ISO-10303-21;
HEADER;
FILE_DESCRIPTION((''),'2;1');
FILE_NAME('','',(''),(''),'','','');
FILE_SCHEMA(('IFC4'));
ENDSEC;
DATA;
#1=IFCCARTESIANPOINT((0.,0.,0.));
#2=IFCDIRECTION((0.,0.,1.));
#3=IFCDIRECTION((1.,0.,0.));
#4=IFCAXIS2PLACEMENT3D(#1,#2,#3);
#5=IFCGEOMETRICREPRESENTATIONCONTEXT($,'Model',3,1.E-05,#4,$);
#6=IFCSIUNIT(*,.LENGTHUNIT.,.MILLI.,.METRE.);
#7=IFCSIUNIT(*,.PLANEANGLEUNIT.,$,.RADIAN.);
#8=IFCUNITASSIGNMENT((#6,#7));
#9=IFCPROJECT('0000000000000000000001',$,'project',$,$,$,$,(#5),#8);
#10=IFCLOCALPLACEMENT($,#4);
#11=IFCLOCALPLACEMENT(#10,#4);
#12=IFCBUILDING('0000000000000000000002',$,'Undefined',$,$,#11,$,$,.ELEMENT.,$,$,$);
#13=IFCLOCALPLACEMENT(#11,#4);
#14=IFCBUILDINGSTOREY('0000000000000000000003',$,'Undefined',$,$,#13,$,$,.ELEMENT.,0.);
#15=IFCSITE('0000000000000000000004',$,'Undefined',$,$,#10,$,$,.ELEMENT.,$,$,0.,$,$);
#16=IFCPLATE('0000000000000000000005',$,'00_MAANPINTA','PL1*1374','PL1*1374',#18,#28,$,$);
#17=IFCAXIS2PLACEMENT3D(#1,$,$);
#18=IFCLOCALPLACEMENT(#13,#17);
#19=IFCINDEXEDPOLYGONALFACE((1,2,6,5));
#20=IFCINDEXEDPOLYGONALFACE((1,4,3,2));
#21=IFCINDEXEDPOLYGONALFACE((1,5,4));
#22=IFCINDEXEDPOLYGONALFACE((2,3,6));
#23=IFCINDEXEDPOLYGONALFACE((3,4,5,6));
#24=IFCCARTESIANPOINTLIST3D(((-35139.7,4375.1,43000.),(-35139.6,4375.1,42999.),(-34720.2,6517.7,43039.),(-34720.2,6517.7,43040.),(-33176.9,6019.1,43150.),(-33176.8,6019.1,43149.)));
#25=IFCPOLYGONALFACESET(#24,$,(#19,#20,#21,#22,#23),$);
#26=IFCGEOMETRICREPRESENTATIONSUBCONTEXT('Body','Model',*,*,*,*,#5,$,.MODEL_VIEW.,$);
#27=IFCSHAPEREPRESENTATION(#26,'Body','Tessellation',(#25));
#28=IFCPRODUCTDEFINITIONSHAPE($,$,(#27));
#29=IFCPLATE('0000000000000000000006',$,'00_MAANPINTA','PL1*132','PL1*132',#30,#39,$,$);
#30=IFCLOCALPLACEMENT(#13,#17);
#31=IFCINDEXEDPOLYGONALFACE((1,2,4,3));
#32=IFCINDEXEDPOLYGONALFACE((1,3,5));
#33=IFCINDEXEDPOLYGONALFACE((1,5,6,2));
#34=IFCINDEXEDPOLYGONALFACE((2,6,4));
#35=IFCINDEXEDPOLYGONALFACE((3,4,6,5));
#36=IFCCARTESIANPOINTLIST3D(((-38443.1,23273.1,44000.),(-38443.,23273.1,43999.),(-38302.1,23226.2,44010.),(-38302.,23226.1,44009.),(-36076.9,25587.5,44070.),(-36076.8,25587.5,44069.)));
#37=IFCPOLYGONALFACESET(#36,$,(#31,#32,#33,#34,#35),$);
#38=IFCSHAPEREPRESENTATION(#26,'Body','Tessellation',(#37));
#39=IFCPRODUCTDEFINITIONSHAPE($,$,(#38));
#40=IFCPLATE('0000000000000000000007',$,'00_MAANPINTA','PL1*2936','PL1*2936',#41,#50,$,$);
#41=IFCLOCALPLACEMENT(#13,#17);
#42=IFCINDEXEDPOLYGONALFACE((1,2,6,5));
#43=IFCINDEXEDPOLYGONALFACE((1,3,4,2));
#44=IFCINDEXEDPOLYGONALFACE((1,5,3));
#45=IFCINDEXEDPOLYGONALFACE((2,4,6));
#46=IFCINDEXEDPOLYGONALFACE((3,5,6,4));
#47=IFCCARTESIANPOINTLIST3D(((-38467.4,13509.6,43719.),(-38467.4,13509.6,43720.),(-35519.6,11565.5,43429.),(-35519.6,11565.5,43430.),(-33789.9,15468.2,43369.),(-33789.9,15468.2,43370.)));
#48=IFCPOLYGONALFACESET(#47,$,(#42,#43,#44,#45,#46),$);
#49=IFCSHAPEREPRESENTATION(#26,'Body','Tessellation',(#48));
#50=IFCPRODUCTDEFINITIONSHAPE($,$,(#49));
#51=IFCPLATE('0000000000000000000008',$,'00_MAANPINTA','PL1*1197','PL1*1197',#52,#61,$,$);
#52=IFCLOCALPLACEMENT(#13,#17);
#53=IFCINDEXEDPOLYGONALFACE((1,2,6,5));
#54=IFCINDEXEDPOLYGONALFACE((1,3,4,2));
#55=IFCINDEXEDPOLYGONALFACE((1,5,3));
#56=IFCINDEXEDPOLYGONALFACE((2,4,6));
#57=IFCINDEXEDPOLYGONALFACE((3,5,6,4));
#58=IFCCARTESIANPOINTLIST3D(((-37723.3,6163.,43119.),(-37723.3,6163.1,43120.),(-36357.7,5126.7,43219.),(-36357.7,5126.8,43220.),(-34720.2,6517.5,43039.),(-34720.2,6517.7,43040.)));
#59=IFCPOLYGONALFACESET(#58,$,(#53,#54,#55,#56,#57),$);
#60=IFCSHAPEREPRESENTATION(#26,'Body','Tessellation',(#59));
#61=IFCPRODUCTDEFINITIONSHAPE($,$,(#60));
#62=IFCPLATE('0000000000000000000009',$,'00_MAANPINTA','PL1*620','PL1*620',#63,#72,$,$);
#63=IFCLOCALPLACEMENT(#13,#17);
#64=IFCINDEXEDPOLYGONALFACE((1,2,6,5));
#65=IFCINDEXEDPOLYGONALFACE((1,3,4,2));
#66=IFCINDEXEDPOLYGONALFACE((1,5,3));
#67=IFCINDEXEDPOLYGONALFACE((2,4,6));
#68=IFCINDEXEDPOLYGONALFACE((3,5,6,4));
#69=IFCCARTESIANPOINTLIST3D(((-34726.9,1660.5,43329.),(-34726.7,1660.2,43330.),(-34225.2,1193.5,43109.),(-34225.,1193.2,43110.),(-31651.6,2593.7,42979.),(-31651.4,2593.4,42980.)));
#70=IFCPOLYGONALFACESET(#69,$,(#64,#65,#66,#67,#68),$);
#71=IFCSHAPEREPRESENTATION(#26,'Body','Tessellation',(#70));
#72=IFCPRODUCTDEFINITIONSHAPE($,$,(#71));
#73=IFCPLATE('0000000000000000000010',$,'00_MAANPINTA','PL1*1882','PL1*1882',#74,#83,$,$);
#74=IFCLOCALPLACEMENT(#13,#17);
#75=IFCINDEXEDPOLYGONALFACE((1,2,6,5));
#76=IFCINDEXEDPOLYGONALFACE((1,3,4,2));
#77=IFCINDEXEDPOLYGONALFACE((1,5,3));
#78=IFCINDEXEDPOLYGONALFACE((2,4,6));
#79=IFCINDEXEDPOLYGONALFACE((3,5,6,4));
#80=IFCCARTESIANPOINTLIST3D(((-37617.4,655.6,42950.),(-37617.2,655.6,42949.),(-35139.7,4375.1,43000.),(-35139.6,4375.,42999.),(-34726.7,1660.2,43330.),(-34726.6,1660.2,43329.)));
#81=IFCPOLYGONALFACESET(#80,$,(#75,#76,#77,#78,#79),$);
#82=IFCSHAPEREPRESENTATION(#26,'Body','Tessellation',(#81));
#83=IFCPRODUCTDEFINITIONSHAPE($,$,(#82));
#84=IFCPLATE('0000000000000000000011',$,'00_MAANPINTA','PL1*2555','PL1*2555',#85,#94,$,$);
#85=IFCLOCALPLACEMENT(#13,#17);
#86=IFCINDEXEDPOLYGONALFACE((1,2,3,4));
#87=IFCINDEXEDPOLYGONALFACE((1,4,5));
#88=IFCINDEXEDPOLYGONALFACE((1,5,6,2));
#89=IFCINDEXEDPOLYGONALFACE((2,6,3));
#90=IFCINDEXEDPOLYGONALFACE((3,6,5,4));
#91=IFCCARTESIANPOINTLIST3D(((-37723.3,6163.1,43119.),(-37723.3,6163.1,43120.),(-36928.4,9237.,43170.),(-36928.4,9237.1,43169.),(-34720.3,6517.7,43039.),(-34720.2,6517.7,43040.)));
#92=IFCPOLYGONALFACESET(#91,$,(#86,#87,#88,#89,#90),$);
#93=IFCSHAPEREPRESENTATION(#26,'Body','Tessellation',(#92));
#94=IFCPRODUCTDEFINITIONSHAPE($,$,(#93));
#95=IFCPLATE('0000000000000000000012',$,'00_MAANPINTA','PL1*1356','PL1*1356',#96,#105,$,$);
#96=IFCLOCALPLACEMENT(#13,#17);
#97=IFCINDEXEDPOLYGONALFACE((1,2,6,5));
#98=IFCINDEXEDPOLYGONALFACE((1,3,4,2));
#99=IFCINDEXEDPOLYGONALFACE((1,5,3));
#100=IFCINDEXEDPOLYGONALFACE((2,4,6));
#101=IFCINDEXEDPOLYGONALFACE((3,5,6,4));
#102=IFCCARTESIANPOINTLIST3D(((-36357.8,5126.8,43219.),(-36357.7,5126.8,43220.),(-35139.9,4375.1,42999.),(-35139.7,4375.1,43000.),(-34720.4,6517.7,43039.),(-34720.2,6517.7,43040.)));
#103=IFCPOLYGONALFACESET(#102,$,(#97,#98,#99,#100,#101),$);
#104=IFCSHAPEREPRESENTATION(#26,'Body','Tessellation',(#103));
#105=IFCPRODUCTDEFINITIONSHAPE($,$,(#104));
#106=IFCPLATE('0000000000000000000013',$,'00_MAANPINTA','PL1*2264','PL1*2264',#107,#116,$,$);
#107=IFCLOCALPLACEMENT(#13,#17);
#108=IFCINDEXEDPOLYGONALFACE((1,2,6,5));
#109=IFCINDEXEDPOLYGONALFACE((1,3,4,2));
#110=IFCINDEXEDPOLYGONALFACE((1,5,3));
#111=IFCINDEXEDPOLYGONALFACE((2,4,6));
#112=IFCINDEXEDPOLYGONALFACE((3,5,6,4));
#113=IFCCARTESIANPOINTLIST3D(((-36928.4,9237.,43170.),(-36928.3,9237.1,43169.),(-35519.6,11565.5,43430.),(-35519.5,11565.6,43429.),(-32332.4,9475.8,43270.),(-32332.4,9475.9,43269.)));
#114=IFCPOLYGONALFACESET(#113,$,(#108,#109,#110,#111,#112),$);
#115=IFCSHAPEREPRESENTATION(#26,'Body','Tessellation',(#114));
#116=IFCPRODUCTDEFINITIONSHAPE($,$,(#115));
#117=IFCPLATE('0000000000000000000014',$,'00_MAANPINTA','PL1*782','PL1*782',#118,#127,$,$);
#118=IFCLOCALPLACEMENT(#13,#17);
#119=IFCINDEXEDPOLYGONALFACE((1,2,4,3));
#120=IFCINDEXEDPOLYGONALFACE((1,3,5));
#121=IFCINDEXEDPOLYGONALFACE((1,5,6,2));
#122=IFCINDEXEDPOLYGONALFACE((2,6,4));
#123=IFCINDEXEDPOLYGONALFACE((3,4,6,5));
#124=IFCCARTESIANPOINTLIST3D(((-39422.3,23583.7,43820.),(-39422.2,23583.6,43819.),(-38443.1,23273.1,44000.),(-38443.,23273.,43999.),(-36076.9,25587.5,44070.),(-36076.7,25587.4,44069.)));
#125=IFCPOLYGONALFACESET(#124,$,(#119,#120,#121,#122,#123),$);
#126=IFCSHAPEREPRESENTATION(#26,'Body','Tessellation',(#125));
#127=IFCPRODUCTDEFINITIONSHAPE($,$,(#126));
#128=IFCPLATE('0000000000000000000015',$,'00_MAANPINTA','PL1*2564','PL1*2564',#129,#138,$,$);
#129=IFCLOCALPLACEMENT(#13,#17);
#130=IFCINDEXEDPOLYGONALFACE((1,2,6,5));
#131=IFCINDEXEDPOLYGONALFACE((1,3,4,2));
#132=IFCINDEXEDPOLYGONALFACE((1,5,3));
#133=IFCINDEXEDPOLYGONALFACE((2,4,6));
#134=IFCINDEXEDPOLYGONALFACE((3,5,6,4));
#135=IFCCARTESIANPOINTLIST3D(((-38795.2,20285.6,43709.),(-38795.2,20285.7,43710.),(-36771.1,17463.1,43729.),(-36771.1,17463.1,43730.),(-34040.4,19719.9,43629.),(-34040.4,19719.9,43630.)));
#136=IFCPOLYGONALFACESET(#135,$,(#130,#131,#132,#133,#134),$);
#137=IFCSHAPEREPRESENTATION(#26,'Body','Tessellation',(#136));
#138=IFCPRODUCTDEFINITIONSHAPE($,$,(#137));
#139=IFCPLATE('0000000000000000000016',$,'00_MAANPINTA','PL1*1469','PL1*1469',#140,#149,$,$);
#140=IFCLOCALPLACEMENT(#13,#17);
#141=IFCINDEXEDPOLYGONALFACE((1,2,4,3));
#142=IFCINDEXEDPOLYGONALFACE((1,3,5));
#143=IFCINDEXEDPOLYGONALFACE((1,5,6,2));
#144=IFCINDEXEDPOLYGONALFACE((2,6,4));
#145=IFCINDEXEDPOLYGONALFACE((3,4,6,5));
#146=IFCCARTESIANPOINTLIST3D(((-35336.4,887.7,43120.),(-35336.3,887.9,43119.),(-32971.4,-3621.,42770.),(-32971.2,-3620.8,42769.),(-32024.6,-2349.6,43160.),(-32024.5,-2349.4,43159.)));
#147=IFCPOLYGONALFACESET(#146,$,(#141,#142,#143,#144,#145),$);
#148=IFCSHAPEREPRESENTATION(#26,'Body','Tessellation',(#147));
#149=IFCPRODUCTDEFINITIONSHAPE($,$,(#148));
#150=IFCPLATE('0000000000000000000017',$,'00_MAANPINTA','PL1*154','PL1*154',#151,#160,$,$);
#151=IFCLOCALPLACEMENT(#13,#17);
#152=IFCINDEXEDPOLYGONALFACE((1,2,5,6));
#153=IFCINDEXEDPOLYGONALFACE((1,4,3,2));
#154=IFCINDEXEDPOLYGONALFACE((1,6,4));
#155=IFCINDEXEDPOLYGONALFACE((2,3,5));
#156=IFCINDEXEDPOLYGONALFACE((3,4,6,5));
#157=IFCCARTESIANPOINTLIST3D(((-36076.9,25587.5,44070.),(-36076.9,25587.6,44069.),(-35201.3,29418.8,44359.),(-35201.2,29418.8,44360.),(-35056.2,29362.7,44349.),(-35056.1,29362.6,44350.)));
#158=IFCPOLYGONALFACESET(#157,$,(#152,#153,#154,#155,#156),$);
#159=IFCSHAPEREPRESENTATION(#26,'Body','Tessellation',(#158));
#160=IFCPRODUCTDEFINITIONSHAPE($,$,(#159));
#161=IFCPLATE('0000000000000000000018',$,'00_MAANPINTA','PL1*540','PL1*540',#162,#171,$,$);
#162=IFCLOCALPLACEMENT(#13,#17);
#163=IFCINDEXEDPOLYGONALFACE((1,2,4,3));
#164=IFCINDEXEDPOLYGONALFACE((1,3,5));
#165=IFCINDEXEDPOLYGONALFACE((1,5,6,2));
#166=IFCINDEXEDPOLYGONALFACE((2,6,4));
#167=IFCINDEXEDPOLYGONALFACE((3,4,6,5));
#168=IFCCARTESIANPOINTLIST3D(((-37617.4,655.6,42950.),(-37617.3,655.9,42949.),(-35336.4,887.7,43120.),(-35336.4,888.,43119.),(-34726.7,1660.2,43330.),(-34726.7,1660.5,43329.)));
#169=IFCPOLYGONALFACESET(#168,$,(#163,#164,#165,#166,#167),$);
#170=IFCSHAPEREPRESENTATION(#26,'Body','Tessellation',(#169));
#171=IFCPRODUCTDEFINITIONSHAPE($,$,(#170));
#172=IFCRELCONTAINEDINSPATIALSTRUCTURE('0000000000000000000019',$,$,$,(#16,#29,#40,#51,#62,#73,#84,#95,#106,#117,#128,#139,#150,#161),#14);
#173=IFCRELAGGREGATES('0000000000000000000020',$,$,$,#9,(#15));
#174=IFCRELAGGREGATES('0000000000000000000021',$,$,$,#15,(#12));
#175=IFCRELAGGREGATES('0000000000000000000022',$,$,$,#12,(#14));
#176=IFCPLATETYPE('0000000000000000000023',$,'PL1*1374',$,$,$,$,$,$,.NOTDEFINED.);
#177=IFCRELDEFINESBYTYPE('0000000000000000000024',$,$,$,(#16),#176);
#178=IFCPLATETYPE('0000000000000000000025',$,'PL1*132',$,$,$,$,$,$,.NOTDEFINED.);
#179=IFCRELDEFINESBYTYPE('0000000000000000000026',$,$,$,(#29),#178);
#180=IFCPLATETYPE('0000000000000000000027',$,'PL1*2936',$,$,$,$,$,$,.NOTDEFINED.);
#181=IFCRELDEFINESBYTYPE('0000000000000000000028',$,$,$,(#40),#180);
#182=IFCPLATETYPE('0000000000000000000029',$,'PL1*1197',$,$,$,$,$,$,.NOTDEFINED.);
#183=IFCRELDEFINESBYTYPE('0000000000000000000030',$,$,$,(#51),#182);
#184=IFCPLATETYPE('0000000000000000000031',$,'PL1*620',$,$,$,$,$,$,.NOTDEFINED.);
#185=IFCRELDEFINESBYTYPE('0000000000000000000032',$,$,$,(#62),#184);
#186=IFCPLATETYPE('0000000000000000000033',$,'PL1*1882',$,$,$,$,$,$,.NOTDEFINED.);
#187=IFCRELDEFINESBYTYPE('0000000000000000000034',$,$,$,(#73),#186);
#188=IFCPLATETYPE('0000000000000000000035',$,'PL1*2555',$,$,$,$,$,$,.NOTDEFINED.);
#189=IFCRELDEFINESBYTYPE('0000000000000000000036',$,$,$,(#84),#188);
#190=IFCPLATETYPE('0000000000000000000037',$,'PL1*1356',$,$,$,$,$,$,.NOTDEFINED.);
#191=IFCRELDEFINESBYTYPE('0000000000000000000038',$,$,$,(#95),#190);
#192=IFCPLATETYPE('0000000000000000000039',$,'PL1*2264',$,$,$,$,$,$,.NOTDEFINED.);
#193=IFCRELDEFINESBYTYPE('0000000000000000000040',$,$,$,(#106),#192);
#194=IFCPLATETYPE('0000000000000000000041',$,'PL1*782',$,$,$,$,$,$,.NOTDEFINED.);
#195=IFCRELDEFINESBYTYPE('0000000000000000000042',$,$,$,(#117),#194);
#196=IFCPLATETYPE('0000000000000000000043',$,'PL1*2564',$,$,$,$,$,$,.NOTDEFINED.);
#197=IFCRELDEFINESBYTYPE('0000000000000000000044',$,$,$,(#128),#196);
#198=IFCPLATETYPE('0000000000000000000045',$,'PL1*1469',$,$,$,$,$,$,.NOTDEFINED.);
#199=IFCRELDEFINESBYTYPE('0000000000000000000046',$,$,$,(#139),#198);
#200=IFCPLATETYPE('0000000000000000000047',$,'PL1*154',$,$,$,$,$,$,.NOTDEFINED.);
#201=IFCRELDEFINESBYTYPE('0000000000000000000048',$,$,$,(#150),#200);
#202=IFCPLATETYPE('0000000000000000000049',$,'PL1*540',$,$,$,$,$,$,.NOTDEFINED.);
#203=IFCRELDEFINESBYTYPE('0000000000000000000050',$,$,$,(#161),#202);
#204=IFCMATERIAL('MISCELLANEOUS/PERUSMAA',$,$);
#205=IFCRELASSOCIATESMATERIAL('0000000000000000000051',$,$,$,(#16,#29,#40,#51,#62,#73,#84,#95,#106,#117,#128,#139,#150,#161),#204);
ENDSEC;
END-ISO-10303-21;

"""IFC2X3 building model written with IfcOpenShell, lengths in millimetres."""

from ifc_helpers import new_model, si_unit, frame, origin_with_axes, place, context, subcontext, project, spatial, polyline, outline, extrude, material, type_object, element, save


model = new_model("IFC2X3")

# Units and contexts
model_context = context("Model", 3, precision=1e-05, world=origin_with_axes())
body_context = subcontext(model_context, "Body", "Model", "MODEL_VIEW")
ifc_project = project(units=[si_unit("LENGTHUNIT", "METRE", prefix="MILLI"), si_unit("PLANEANGLEUNIT", "RADIAN")], contexts=[model_context])

# Site, building, storey
site_placement = place(None, origin_with_axes())
site = spatial("IfcSite", under=ifc_project, at=site_placement, Name="Undefined", CompositionType="ELEMENT", RefElevation=0.0)
building_placement = place(site_placement, origin_with_axes())
building = spatial("IfcBuilding", under=site, at=building_placement, Name="Undefined", CompositionType="ELEMENT")
storey_placement = place(building_placement, origin_with_axes())
storey = spatial("IfcBuildingStorey", under=building, at=storey_placement, Name="Undefined", CompositionType="ELEMENT", Elevation=0.0)

# Plates
ifc_material = material(Name="MISCELLANEOUS/PERUSMAA")
plate_type_1 = type_object("IfcPlateType", Name="PL1*1374", PredefinedType="NOTDEFINED")
plate_1_placement = place(storey_placement, frame((-34720.2, 6517.7, 43039.5), z_axis=(0.072513, 0.004423, -0.997358), x_axis=(0.949409, -0.306667, 0.067667)))
element("IfcPlate", 1, at=plate_1_placement, inside=storey, type_object=plate_type_1, material=ifc_material, Name="00_MAANPINTA", Description="PL1*1374", ObjectType="PL1*1374", context=body_context, shape_type="SweptSolid", body=[
    extrude(outline(polyline([(0.0, 0.0), (1625.6, 0.0), (256.1, 2168.6), (0.0, 0.0)])), frame((0.0, 0.0, -0.5), z_axis=(0.0, 0.0, 1.0), x_axis=(1.0, 0.0, 0.0)), (0.0, 0.0, 1.0), 1.0),
])
plate_type_2 = type_object("IfcPlateType", Name="PL1*132", PredefinedType="NOTDEFINED")
plate_2_placement = place(storey_placement, frame((-36076.8, 25587.5, 44069.5), z_axis=(0.060265, -0.031439, -0.997687), x_axis=(-0.685691, -0.727658, -0.018489)))
element("IfcPlate", 2, at=plate_2_placement, inside=storey, type_object=plate_type_2, material=ifc_material, Name="00_MAANPINTA", Description="PL1*132", ObjectType="PL1*132", context=body_context, shape_type="SweptSolid", body=[
    extrude(outline(polyline([(0.0, 0.0), (3245.2, 0.0), (3307.9, 135.2), (0.0, 0.0)])), frame((0.0, 0.0, -0.5), z_axis=(0.0, 0.0, 1.0), x_axis=(1.0, 0.0, 0.0)), (0.0, 0.0, 1.0), 1.0),
])
plate_type_3 = type_object("IfcPlateType", Name="PL1*2936", PredefinedType="NOTDEFINED")
plate_3_placement = place(storey_placement, frame((-35519.6, 11565.5, 43429.5), z_axis=(-0.083658, 0.021762, -0.996257), x_axis=(-0.831998, 0.548707, 0.081851)))
element("IfcPlate", 3, at=plate_3_placement, inside=storey, type_object=plate_type_3, material=ifc_material, Name="00_MAANPINTA", Description="PL1*2936", ObjectType="PL1*2936", context=body_context, shape_type="SweptSolid", body=[
    extrude(outline(polyline([(0.0, 0.0), (3543.0, 0.0), (697.4, 4211.9), (0.0, 0.0)])), frame((0.0, 0.0, -0.5), z_axis=(0.0, 0.0, 1.0), x_axis=(1.0, 0.0, 0.0)), (0.0, 0.0, 1.0), 1.0),
])
plate_type_4 = type_object("IfcPlateType", Name="PL1*1197", PredefinedType="NOTDEFINED")
plate_4_placement = place(storey_placement, frame((-36357.7, 5126.7, 43219.5), z_axis=(-0.013108, -0.113142, -0.993492), x_axis=(-0.795254, 0.603473, -0.058233)))
element("IfcPlate", 4, at=plate_4_placement, inside=storey, type_object=plate_type_4, material=ifc_material, Name="00_MAANPINTA", Description="PL1*1197", ObjectType="PL1*1197", context=body_context, shape_type="SweptSolid", body=[
    extrude(outline(polyline([(0.0, 0.0), (1717.2, 0.0), (-452.4, 2108.0), (0.0, 0.0)])), frame((0.0, 0.0, -0.5), z_axis=(0.0, 0.0, 1.0), x_axis=(1.0, 0.0, 0.0)), (0.0, 0.0, 1.0), 1.0),
])
plate_type_5 = type_object("IfcPlateType", Name="PL1*620", PredefinedType="NOTDEFINED")
plate_5_placement = place(storey_placement, frame((-34225.1, 1193.3, 43109.5), z_axis=(-0.184063, 0.25006, -0.950574), x_axis=(-0.696913, 0.648778, 0.305615)))
element("IfcPlate", 5, at=plate_5_placement, inside=storey, type_object=plate_type_5, material=ifc_material, Name="00_MAANPINTA", Description="PL1*620", ObjectType="PL1*620", context=body_context, shape_type="SweptSolid", body=[
    extrude(outline(polyline([(0.0, 0.0), (719.9, 0.0), (-924.9, 2783.1), (0.0, 0.0)])), frame((0.0, 0.0, -0.5), z_axis=(0.0, 0.0, 1.0), x_axis=(1.0, 0.0, 0.0)), (0.0, 0.0, 1.0), 1.0),
])
plate_type_6 = type_object("IfcPlateType", Name="PL1*1882", PredefinedType="NOTDEFINED")
plate_6_placement = place(storey_placement, frame((-35139.6, 4375.0, 42999.5), z_axis=(0.162048, -0.094742, -0.982224), x_axis=(0.14932, -0.981564, 0.119313)))
element("IfcPlate", 6, at=plate_6_placement, inside=storey, type_object=plate_type_6, material=ifc_material, Name="00_MAANPINTA", Description="PL1*1882", ObjectType="PL1*1882", context=body_context, shape_type="SweptSolid", body=[
    extrude(outline(polyline([(0.0, 0.0), (2765.8, 0.0), (3274.9, 3041.4), (0.0, 0.0)])), frame((0.0, 0.0, -0.5), z_axis=(0.0, 0.0, 1.0), x_axis=(1.0, 0.0, 0.0)), (0.0, 0.0, 1.0), 1.0),
])
plate_type_7 = type_object("IfcPlateType", Name="PL1*2555", PredefinedType="NOTDEFINED")
plate_7_placement = place(storey_placement, frame((-36928.4, 9237.0, 43169.5), z_axis=(-0.029438, 0.023867, -0.999282), x_axis=(0.629923, -0.775772, -0.037086)))
element("IfcPlate", 7, at=plate_7_placement, inside=storey, type_object=plate_type_7, material=ifc_material, Name="00_MAANPINTA", Description="PL1*2555", ObjectType="PL1*2555", context=body_context, shape_type="SweptSolid", body=[
    extrude(outline(polyline([(0.0, 0.0), (3505.4, 0.0), (1885.8, 2554.9), (0.0, 0.0)])), frame((0.0, 0.0, -0.5), z_axis=(0.0, 0.0, 1.0), x_axis=(1.0, 0.0, 0.0)), (0.0, 0.0, 1.0), 1.0),
])
plate_type_8 = type_object("IfcPlateType", Name="PL1*1356", PredefinedType="NOTDEFINED")
plate_8_placement = place(storey_placement, frame((-35139.8, 4375.1, 42999.5), z_axis=(-0.149019, 0.047615, -0.987687), x_axis=(-0.841091, 0.519118, 0.151927)))
element("IfcPlate", 8, at=plate_8_placement, inside=storey, type_object=plate_type_8, material=ifc_material, Name="00_MAANPINTA", Description="PL1*1356", ObjectType="PL1*1356", context=body_context, shape_type="SweptSolid", body=[
    extrude(outline(polyline([(0.0, 0.0), (1448.1, 0.0), (765.5, 2045.0), (0.0, 0.0)])), frame((0.0, 0.0, -0.5), z_axis=(0.0, 0.0, 1.0), x_axis=(1.0, 0.0, 0.0)), (0.0, 0.0, 1.0), 1.0),
])
plate_type_9 = type_object("IfcPlateType", Name="PL1*2264", PredefinedType="NOTDEFINED")
plate_9_placement = place(storey_placement, frame((-35519.5, 11565.6, 43429.5), z_axis=(0.01639, 0.101157, -0.994735), x_axis=(0.835529, -0.547843, -0.041945)))
element("IfcPlate", 9, at=plate_9_placement, inside=storey, type_object=plate_type_9, material=ifc_material, Name="00_MAANPINTA", Description="PL1*2264", ObjectType="PL1*2264", context=body_context, shape_type="SweptSolid", body=[
    extrude(outline(polyline([(0.0, 0.0), (3814.5, 0.0), (109.5, 2731.7), (0.0, 0.0)])), frame((0.0, 0.0, -0.5), z_axis=(0.0, 0.0, 1.0), x_axis=(1.0, 0.0, 0.0)), (0.0, 0.0, 1.0), 1.0),
])
plate_type_10 = type_object("IfcPlateType", Name="PL1*782", PredefinedType="NOTDEFINED")
plate_10_placement = place(storey_placement, frame((-36076.8, 25587.5, 44069.5), z_axis=(0.143527, -0.117019, -0.982704), x_axis=(-0.714734, -0.699077, -0.021144)))
element("IfcPlate", 10, at=plate_10_placement, inside=storey, type_object=plate_type_10, material=ifc_material, Name="00_MAANPINTA", Description="PL1*782", ObjectType="PL1*782", context=body_context, shape_type="SweptSolid", body=[
    extrude(outline(polyline([(0.0, 0.0), (3310.7, 0.0), (3797.2, 922.5), (0.0, 0.0)])), frame((0.0, 0.0, -0.5), z_axis=(0.0, 0.0, 1.0), x_axis=(1.0, 0.0, 0.0)), (0.0, 0.0, 1.0), 1.0),
])
plate_type_11 = type_object("IfcPlateType", Name="PL1*2564", PredefinedType="NOTDEFINED")
plate_11_placement = place(storey_placement, frame((-36771.1, 17463.1, 43729.5), z_axis=(-0.019309, -0.02093, -0.999594), x_axis=(-0.582755, 0.812628, -0.005758)))
element("IfcPlate", 11, at=plate_11_placement, inside=storey, type_object=plate_type_11, material=ifc_material, Name="00_MAANPINTA", Description="PL1*2564", ObjectType="PL1*2564", context=body_context, shape_type="SweptSolid", body=[
    extrude(outline(polyline([(0.0, 0.0), (3473.4, 0.0), (243.2, 3535.6), (0.0, 0.0)])), frame((0.0, 0.0, -0.5), z_axis=(0.0, 0.0, 1.0), x_axis=(1.0, 0.0, 0.0)), (0.0, 0.0, 1.0), 1.0),
])
plate_type_12 = type_object("IfcPlateType", Name="PL1*1469", PredefinedType="NOTDEFINED")
plate_12_placement = place(storey_placement, frame((-35336.3, 887.8, 43119.5), z_axis=(0.175152, 0.167192, -0.970242), x_axis=(0.715074, -0.698996, 0.008637)))
element("IfcPlate", 12, at=plate_12_placement, inside=storey, type_object=plate_type_12, material=ifc_material, Name="00_MAANPINTA", Description="PL1*1469", ObjectType="PL1*1469", context=body_context, shape_type="SweptSolid", body=[
    extrude(outline(polyline([(0.0, 0.0), (4631.4, 0.0), (4839.7, 1619.1), (0.0, 0.0)])), frame((0.0, 0.0, -0.5), z_axis=(0.0, 0.0, 1.0), x_axis=(1.0, 0.0, 0.0)), (0.0, 0.0, 1.0), 1.0),
])
plate_type_13 = type_object("IfcPlateType", Name="PL1*154", PredefinedType="NOTDEFINED")
plate_13_placement = place(storey_placement, frame((-35201.2, 29418.8, 44359.5), z_axis=(-0.036269, 0.083668, -0.995833), x_axis=(0.930718, -0.360068, -0.06415)))
element("IfcPlate", 13, at=plate_13_placement, inside=storey, type_object=plate_type_13, material=ifc_material, Name="00_MAANPINTA", Description="PL1*154", ObjectType="PL1*154", context=body_context, shape_type="SweptSolid", body=[
    extrude(outline(polyline([(0.0, 0.0), (155.9, 0.0), (583.1, 3897.3), (0.0, 0.0)])), frame((0.0, 0.0, -0.5), z_axis=(0.0, 0.0, 1.0), x_axis=(1.0, 0.0, 0.0)), (0.0, 0.0, 1.0), 1.0),
])
plate_type_14 = type_object("IfcPlateType", Name="PL1*540", PredefinedType="NOTDEFINED")
plate_14_placement = place(storey_placement, frame((-34726.7, 1660.4, 43329.5), z_axis=(0.049587, 0.225371, -0.97301), x_axis=(-0.605905, -0.767677, -0.208689)))
element("IfcPlate", 14, at=plate_14_placement, inside=storey, type_object=plate_type_14, material=ifc_material, Name="00_MAANPINTA", Description="PL1*540", ObjectType="PL1*540", context=body_context, shape_type="SweptSolid", body=[
    extrude(outline(polyline([(0.0, 0.0), (1006.3, 0.0), (2602.0, 1655.1), (0.0, 0.0)])), frame((0.0, 0.0, -0.5), z_axis=(0.0, 0.0, 1.0), x_axis=(1.0, 0.0, 0.0)), (0.0, 0.0, 1.0), 1.0),
])

save(model, "model.ifc")
